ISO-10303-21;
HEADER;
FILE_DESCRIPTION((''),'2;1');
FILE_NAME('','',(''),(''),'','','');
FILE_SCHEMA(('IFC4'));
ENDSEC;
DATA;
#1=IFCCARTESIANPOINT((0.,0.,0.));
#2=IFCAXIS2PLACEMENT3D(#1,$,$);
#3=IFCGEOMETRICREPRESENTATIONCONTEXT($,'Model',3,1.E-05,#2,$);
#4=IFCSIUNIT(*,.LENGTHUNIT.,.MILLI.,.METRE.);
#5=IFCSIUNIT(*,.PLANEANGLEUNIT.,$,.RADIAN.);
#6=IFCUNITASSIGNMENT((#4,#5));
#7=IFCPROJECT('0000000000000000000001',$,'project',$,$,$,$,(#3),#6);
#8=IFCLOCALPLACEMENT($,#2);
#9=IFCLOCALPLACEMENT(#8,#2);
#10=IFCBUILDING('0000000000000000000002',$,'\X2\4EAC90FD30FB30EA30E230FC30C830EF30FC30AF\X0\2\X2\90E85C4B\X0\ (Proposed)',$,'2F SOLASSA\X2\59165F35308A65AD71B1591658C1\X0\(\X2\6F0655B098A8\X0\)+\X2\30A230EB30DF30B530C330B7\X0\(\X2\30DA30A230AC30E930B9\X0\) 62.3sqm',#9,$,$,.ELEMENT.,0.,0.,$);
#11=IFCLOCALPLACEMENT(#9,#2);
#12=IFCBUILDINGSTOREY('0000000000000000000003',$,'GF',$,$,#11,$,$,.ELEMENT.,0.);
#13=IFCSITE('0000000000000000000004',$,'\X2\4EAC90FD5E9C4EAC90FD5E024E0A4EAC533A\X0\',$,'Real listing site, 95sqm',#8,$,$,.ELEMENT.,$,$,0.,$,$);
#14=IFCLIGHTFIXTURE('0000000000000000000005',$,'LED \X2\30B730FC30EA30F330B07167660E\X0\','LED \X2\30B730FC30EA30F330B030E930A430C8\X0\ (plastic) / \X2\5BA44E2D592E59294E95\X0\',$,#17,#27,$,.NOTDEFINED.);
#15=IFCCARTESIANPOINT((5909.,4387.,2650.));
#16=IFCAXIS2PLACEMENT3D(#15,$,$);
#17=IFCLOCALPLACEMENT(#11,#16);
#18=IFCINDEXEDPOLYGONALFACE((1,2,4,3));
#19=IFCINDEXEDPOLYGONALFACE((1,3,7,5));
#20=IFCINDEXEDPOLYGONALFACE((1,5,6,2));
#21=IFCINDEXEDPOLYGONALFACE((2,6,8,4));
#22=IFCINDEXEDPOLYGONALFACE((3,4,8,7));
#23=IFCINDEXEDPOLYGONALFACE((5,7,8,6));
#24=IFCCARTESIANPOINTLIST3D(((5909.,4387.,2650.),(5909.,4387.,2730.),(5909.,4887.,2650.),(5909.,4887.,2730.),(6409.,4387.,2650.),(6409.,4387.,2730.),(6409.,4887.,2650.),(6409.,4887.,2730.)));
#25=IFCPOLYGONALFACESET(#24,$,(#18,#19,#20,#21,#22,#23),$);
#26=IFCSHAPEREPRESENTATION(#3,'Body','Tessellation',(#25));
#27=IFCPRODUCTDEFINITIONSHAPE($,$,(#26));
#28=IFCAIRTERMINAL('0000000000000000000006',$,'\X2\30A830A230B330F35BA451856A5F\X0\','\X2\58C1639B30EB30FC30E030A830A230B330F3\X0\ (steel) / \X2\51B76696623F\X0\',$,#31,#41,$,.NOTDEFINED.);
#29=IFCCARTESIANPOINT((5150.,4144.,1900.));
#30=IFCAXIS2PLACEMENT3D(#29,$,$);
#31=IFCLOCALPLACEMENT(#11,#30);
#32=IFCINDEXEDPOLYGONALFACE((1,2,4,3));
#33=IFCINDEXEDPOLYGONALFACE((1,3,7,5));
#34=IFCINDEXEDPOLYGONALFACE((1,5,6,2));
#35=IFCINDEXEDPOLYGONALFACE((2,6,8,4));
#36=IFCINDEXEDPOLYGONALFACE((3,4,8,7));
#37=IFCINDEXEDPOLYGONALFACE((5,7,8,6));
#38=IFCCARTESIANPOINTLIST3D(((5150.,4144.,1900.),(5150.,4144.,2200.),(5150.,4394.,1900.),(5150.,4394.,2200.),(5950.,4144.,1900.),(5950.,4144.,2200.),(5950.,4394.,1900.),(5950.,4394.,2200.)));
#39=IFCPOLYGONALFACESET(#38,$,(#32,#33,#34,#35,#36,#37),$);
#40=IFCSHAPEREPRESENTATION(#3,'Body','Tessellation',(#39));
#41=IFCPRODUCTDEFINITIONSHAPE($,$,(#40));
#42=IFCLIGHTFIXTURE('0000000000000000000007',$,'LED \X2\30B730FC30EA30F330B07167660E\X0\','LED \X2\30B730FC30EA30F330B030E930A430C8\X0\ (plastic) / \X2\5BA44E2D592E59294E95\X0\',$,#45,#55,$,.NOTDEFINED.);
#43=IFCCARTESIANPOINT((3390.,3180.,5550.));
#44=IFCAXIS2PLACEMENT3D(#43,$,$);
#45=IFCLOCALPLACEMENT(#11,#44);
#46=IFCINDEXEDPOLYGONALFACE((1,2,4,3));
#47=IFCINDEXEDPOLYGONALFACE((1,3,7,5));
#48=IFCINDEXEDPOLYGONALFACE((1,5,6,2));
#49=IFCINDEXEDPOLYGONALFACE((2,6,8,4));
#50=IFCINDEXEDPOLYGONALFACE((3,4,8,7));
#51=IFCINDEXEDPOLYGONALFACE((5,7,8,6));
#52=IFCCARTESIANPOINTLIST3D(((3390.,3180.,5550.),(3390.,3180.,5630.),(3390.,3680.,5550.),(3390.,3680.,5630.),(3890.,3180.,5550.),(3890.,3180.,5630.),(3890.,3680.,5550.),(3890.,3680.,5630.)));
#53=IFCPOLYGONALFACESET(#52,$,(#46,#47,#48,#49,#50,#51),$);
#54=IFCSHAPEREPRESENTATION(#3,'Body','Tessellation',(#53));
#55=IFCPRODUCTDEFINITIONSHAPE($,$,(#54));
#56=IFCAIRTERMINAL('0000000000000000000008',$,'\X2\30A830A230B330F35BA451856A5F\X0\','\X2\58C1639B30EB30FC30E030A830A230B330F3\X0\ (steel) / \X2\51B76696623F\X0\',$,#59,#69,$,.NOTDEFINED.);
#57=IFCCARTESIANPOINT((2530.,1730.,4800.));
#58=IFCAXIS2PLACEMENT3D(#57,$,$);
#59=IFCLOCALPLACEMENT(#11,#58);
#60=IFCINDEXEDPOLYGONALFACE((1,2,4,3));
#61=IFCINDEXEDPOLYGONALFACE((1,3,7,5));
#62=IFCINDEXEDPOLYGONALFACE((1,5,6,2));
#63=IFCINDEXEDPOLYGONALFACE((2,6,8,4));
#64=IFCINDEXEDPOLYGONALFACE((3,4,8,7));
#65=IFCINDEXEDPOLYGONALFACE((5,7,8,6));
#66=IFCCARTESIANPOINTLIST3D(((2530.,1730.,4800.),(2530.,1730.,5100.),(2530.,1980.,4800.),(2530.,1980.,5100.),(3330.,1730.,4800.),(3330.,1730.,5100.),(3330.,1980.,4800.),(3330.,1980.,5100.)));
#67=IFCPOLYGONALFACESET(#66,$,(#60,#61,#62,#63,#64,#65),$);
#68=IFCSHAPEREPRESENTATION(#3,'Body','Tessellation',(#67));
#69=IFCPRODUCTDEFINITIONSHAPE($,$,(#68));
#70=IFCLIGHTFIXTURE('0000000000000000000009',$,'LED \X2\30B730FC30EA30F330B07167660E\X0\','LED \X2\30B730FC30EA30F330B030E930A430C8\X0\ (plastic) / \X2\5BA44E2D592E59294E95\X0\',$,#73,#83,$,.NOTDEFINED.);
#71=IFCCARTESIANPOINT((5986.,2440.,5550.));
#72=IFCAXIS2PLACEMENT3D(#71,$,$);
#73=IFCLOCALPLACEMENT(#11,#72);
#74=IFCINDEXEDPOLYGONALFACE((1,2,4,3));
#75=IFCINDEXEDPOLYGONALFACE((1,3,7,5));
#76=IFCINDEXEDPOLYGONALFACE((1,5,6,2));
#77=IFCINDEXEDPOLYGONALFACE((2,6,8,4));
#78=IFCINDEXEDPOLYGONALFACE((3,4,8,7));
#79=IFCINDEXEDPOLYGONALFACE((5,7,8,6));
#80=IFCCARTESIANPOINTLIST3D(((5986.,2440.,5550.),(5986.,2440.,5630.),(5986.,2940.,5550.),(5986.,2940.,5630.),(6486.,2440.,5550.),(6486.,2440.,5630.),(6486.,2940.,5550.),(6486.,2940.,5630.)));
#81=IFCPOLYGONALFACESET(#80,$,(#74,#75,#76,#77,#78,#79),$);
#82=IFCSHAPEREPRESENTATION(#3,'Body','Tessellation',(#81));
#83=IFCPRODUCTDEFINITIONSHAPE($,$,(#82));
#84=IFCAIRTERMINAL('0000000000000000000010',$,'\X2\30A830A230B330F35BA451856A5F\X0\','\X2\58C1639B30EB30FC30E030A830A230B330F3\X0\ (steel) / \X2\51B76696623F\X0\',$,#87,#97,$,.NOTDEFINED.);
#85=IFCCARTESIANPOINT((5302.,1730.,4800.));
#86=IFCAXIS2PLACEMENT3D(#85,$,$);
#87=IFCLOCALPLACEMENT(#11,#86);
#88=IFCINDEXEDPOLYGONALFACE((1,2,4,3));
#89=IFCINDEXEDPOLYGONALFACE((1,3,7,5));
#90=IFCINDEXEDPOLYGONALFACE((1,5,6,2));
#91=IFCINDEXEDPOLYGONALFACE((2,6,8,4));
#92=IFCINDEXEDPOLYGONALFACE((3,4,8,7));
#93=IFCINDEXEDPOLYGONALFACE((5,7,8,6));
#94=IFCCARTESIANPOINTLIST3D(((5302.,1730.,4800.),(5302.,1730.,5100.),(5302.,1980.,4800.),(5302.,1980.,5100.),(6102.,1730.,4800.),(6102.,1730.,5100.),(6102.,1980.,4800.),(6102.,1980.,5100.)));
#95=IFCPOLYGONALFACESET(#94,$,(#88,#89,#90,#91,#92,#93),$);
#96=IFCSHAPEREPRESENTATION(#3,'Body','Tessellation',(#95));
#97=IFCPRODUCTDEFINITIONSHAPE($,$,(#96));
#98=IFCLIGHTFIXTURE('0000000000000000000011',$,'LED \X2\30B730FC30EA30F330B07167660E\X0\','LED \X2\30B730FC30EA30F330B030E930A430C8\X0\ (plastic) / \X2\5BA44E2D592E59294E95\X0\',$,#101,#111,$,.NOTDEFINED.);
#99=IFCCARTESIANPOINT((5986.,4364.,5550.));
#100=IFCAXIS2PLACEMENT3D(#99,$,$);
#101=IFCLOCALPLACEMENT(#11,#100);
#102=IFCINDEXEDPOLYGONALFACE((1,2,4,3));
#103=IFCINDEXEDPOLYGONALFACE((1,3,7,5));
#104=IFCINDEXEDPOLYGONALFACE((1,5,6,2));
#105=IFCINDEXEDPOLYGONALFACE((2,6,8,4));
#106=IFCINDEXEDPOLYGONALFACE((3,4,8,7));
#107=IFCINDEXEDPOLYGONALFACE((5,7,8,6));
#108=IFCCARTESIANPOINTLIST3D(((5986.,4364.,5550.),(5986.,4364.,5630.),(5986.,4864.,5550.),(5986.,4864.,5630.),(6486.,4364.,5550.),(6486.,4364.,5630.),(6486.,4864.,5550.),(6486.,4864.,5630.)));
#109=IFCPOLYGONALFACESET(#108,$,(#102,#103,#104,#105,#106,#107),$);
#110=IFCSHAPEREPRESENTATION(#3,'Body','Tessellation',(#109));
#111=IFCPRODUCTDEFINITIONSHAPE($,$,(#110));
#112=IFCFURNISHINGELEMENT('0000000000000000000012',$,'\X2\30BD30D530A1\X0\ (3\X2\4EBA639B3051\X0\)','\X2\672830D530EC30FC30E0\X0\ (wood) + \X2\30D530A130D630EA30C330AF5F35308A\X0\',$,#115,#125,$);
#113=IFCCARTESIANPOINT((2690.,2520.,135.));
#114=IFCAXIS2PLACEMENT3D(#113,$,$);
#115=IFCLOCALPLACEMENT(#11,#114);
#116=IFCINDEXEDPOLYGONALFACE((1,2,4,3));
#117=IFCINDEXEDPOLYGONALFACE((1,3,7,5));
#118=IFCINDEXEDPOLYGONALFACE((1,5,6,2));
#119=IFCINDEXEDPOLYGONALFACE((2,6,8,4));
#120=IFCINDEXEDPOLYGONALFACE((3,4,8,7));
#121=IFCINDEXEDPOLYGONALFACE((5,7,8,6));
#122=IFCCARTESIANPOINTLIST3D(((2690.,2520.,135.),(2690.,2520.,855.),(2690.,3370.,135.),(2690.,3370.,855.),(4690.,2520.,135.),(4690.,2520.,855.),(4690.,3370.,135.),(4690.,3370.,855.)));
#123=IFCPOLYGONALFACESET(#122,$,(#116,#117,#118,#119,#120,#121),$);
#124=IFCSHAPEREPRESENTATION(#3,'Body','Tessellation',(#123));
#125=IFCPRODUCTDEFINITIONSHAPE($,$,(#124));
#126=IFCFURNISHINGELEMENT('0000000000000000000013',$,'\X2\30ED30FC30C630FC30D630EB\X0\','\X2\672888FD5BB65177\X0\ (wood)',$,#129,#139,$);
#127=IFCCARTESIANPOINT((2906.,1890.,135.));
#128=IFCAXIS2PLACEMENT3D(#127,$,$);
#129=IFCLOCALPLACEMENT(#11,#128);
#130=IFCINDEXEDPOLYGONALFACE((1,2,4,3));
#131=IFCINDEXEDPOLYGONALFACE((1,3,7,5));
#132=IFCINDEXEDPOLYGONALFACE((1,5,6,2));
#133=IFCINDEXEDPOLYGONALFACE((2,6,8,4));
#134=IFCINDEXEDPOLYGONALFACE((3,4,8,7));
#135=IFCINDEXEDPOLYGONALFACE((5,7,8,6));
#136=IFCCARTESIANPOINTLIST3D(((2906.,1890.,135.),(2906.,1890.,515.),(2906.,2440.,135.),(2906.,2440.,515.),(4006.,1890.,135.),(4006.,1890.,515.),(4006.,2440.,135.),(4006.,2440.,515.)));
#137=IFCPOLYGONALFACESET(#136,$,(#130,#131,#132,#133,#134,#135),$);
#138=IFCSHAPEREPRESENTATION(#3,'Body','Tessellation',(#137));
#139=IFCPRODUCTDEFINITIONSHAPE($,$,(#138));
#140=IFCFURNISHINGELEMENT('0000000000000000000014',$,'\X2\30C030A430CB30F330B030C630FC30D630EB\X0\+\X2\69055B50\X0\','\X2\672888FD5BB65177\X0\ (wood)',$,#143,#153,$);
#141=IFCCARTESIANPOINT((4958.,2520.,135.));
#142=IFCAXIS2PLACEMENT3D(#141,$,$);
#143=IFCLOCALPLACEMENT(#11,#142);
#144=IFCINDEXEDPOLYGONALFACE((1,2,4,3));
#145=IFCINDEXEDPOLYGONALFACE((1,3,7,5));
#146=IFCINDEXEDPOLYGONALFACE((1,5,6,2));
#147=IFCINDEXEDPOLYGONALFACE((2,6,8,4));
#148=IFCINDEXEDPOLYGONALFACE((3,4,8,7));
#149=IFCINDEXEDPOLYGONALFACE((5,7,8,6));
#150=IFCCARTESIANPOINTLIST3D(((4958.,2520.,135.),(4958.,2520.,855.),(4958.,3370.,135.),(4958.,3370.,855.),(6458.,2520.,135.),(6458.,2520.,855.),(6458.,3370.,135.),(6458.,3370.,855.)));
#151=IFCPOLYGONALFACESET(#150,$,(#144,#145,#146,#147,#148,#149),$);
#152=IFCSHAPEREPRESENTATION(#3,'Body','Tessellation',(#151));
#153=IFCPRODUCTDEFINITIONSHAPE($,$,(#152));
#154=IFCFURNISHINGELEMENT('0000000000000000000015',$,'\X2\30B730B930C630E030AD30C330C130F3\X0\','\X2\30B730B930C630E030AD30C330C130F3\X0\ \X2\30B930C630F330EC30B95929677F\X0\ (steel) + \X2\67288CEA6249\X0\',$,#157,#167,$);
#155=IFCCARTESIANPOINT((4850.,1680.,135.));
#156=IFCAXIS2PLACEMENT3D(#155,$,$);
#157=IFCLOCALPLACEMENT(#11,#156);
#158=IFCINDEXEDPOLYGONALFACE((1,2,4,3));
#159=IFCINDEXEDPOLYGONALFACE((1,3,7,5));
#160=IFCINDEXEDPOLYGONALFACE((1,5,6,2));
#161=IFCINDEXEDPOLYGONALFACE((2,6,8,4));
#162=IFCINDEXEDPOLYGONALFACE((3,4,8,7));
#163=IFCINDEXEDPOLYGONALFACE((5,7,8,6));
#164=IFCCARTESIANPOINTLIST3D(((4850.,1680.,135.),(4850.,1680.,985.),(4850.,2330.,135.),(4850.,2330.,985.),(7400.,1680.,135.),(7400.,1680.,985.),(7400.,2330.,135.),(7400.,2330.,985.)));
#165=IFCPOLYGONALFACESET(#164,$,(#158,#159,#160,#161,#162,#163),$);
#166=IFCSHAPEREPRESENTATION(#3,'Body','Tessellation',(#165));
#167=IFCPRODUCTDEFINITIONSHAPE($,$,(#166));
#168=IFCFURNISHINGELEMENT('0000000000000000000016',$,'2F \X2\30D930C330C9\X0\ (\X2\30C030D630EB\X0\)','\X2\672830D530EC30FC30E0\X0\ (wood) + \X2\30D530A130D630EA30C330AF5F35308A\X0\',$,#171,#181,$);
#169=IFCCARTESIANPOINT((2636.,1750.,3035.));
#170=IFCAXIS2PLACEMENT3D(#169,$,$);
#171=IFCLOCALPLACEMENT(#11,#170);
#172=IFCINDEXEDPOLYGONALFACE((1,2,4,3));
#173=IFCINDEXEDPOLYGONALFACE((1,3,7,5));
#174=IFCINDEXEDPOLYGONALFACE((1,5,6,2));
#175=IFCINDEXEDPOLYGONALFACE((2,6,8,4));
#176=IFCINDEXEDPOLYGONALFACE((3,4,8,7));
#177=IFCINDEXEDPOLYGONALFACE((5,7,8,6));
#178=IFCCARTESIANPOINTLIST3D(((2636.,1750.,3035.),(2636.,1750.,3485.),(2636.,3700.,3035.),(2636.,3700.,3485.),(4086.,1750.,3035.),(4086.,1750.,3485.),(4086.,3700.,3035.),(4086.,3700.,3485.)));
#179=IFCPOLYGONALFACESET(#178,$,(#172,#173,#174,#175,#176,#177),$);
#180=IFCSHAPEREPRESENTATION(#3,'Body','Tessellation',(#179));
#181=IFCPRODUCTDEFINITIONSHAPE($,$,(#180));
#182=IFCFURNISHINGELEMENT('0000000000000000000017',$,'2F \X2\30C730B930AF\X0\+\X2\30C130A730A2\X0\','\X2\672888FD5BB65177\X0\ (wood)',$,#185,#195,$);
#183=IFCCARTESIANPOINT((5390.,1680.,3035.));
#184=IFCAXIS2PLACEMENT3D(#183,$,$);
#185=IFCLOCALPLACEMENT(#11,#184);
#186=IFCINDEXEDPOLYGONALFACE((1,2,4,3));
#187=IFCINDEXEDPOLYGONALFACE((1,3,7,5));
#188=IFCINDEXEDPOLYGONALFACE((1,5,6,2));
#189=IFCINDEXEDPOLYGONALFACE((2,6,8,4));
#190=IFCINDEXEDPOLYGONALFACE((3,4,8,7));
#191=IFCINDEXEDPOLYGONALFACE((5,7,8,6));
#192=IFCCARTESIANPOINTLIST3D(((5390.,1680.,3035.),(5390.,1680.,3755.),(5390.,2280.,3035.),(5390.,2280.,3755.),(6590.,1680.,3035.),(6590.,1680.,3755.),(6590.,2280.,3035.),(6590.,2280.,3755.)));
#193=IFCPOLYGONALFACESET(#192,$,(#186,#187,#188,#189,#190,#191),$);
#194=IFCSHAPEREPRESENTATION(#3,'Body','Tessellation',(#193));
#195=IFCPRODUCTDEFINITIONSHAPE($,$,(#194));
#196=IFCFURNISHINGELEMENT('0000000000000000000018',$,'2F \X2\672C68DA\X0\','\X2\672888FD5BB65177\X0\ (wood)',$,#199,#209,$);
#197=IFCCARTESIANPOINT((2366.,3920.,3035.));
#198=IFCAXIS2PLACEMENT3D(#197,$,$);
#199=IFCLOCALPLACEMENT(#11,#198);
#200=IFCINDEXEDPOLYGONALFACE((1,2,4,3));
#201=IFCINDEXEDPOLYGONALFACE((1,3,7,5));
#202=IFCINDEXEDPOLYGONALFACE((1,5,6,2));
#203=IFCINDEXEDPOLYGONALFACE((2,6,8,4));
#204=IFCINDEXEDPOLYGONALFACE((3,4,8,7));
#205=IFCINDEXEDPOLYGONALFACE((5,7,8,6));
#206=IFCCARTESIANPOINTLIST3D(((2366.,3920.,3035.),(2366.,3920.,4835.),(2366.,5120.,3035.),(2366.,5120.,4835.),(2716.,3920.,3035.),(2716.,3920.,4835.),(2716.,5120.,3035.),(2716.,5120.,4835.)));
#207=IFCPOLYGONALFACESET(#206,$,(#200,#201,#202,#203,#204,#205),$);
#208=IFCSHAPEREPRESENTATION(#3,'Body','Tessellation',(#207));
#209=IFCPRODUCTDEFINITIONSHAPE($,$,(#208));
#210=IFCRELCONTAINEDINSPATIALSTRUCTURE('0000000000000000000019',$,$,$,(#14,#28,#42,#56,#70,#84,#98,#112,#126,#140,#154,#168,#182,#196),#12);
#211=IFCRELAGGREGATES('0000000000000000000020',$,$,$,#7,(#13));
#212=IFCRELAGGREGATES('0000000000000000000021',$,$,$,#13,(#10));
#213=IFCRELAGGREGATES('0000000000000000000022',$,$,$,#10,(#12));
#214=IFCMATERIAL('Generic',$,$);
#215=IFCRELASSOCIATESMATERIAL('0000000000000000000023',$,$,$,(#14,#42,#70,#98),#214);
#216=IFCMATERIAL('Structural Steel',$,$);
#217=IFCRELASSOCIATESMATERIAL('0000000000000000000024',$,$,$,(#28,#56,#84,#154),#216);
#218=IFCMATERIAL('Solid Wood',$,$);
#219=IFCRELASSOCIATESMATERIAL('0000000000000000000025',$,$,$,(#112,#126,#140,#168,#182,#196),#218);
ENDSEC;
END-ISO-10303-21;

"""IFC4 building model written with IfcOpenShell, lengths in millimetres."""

from ifc_helpers import new_model, si_unit, frame, frame_2d, origin, place, context, project, spatial, rectangle, extrude, material, element, save


model = new_model("IFC4")

# Units and contexts
model_context = context("Model", 3, precision=1e-05, world=origin())
ifc_project = project(units=[si_unit("LENGTHUNIT", "METRE", prefix="MILLI"), si_unit("PLANEANGLEUNIT", "RADIAN")], contexts=[model_context])

# Site, building, storey
site_placement = place(None, origin())
site = spatial("IfcSite", under=ifc_project, at=site_placement, Name="京都府京都市上京区", ObjectType="Real listing site, 95sqm", CompositionType="ELEMENT", RefElevation=0.0)
building_placement = place(site_placement, origin())
building = spatial("IfcBuilding", under=site, at=building_placement, Name="京都・リモートワーク2部屋 (Proposed)", ObjectType="2F SOLASSA外張り断熱外壁(漆喰風)+アルミサッシ(ペアガラス) 62.3sqm", CompositionType="ELEMENT", ElevationOfRefHeight=0.0, ElevationOfTerrain=0.0)
storey_placement = place(building_placement, origin())
storey = spatial("IfcBuildingStorey", under=building, at=storey_placement, Name="GF", CompositionType="ELEMENT", Elevation=0.0)

# Shared definitions
ifc_material_1 = material(Name="Solid Wood")

# Shared definitions
ifc_material_2 = material(Name="Structural Steel")

# Shared definitions
ifc_material_3 = material(Name="Generic")

# Light fixture
light_fixture_1_placement = place(storey_placement, frame((5909.0, 4387.0, 2650.0)))
element("IfcLightFixture", 1, at=light_fixture_1_placement, inside=storey, material=ifc_material_3, Name="LED シーリング照明", Description="LED シーリングライト (plastic) / 室中央天井", PredefinedType="NOTDEFINED", context=model_context, shape_type="SweptSolid", body=[
    extrude(rectangle(XDim=500.0, YDim=500.0, at=frame_2d((250.0, 250.0))), frame((5909.0, 4387.0, 2650.0)), (0.0, 0.0, 1.0), 80.0),
])

# Air terminal
air_terminal_1_placement = place(storey_placement, frame((5150.0, 4144.0, 1900.0)))
element("IfcAirTerminal", 2, at=air_terminal_1_placement, inside=storey, material=ifc_material_2, Name="エアコン室内機", Description="壁掛ルームエアコン (steel) / 冷暖房", PredefinedType="NOTDEFINED", context=model_context, shape_type="SweptSolid", body=[
    extrude(rectangle(XDim=800.0, YDim=250.0, at=frame_2d((400.0, 125.0))), frame((5150.0, 4144.0, 1900.0)), (0.0, 0.0, 1.0), 300.0),
])

# Light fixture
light_fixture_2_placement = place(storey_placement, frame((3390.0, 3180.0, 5550.0)))
element("IfcLightFixture", 3, at=light_fixture_2_placement, inside=storey, material=ifc_material_3, Name="LED シーリング照明", Description="LED シーリングライト (plastic) / 室中央天井", PredefinedType="NOTDEFINED", context=model_context, shape_type="SweptSolid", body=[
    extrude(rectangle(XDim=500.0, YDim=500.0, at=frame_2d((250.0, 250.0))), frame((3390.0, 3180.0, 5550.0)), (0.0, 0.0, 1.0), 80.0),
])

# Air terminal
air_terminal_2_placement = place(storey_placement, frame((2530.0, 1730.0, 4800.0)))
element("IfcAirTerminal", 4, at=air_terminal_2_placement, inside=storey, material=ifc_material_2, Name="エアコン室内機", Description="壁掛ルームエアコン (steel) / 冷暖房", PredefinedType="NOTDEFINED", context=model_context, shape_type="SweptSolid", body=[
    extrude(rectangle(XDim=800.0, YDim=250.0, at=frame_2d((400.0, 125.0))), frame((2530.0, 1730.0, 4800.0)), (0.0, 0.0, 1.0), 300.0),
])

# Light fixture
light_fixture_3_placement = place(storey_placement, frame((5986.0, 2440.0, 5550.0)))
element("IfcLightFixture", 5, at=light_fixture_3_placement, inside=storey, material=ifc_material_3, Name="LED シーリング照明", Description="LED シーリングライト (plastic) / 室中央天井", PredefinedType="NOTDEFINED", context=model_context, shape_type="SweptSolid", body=[
    extrude(rectangle(XDim=500.0, YDim=500.0, at=frame_2d((250.0, 250.0))), frame((5986.0, 2440.0, 5550.0)), (0.0, 0.0, 1.0), 80.0),
])

# Air terminal
air_terminal_3_placement = place(storey_placement, frame((5302.0, 1730.0, 4800.0)))
element("IfcAirTerminal", 6, at=air_terminal_3_placement, inside=storey, material=ifc_material_2, Name="エアコン室内機", Description="壁掛ルームエアコン (steel) / 冷暖房", PredefinedType="NOTDEFINED", context=model_context, shape_type="SweptSolid", body=[
    extrude(rectangle(XDim=800.0, YDim=250.0, at=frame_2d((400.0, 125.0))), frame((5302.0, 1730.0, 4800.0)), (0.0, 0.0, 1.0), 300.0),
])

# Light fixture
light_fixture_4_placement = place(storey_placement, frame((5986.0, 4364.0, 5550.0)))
element("IfcLightFixture", 7, at=light_fixture_4_placement, inside=storey, material=ifc_material_3, Name="LED シーリング照明", Description="LED シーリングライト (plastic) / 室中央天井", PredefinedType="NOTDEFINED", context=model_context, shape_type="SweptSolid", body=[
    extrude(rectangle(XDim=500.0, YDim=500.0, at=frame_2d((250.0, 250.0))), frame((5986.0, 4364.0, 5550.0)), (0.0, 0.0, 1.0), 80.0),
])

# Furnishing elements
furnishing_1_placement = place(storey_placement, frame((2690.0, 2520.0, 135.0)))
element("IfcFurnishingElement", 8, at=furnishing_1_placement, inside=storey, material=ifc_material_1, Name="ソファ (3人掛け)", Description="木フレーム (wood) + ファブリック張り", context=model_context, shape_type="SweptSolid", body=[
    extrude(rectangle(XDim=2000.0, YDim=850.0, at=frame_2d((1000.0, 425.0))), frame((2690.0, 2520.0, 135.0)), (0.0, 0.0, 1.0), 720.0),
])
furnishing_2_placement = place(storey_placement, frame((2906.0, 1890.0, 135.0)))
element("IfcFurnishingElement", 9, at=furnishing_2_placement, inside=storey, material=ifc_material_1, Name="ローテーブル", Description="木製家具 (wood)", context=model_context, shape_type="SweptSolid", body=[
    extrude(rectangle(XDim=1100.0, YDim=550.0, at=frame_2d((550.0, 275.0))), frame((2906.0, 1890.0, 135.0)), (0.0, 0.0, 1.0), 380.0),
])
furnishing_3_placement = place(storey_placement, frame((4958.0, 2520.0, 135.0)))
element("IfcFurnishingElement", 10, at=furnishing_3_placement, inside=storey, material=ifc_material_1, Name="ダイニングテーブル+椅子", Description="木製家具 (wood)", context=model_context, shape_type="SweptSolid", body=[
    extrude(rectangle(XDim=1500.0, YDim=850.0, at=frame_2d((750.0, 425.0))), frame((4958.0, 2520.0, 135.0)), (0.0, 0.0, 1.0), 720.0),
])
furnishing_4_placement = place(storey_placement, frame((4850.0, 1680.0, 135.0)))
element("IfcFurnishingElement", 11, at=furnishing_4_placement, inside=storey, material=ifc_material_2, Name="システムキッチン", Description="システムキッチン ステンレス天板 (steel) + 木質扉", context=model_context, shape_type="SweptSolid", body=[
    extrude(rectangle(XDim=2550.0, YDim=650.0, at=frame_2d((1275.0, 325.0))), frame((4850.0, 1680.0, 135.0)), (0.0, 0.0, 1.0), 850.0),
])
furnishing_5_placement = place(storey_placement, frame((2636.0, 1750.0, 3035.0)))
element("IfcFurnishingElement", 12, at=furnishing_5_placement, inside=storey, material=ifc_material_1, Name="2F ベッド (ダブル)", Description="木フレーム (wood) + ファブリック張り", context=model_context, shape_type="SweptSolid", body=[
    extrude(rectangle(XDim=1450.0, YDim=1950.0, at=frame_2d((725.0, 975.0))), frame((2636.0, 1750.0, 3035.0)), (0.0, 0.0, 1.0), 450.0),
])
furnishing_6_placement = place(storey_placement, frame((5390.0, 1680.0, 3035.0)))
element("IfcFurnishingElement", 13, at=furnishing_6_placement, inside=storey, material=ifc_material_1, Name="2F デスク+チェア", Description="木製家具 (wood)", context=model_context, shape_type="SweptSolid", body=[
    extrude(rectangle(XDim=1200.0, YDim=600.0, at=frame_2d((600.0, 300.0))), frame((5390.0, 1680.0, 3035.0)), (0.0, 0.0, 1.0), 720.0),
])
furnishing_7_placement = place(storey_placement, frame((2366.0, 3920.0, 3035.0)))
element("IfcFurnishingElement", 14, at=furnishing_7_placement, inside=storey, material=ifc_material_1, Name="2F 本棚", Description="木製家具 (wood)", context=model_context, shape_type="SweptSolid", body=[
    extrude(rectangle(XDim=350.0, YDim=1200.0, at=frame_2d((175.0, 600.0))), frame((2366.0, 3920.0, 3035.0)), (0.0, 0.0, 1.0), 1800.0),
])

save(model, "model.ifc")
